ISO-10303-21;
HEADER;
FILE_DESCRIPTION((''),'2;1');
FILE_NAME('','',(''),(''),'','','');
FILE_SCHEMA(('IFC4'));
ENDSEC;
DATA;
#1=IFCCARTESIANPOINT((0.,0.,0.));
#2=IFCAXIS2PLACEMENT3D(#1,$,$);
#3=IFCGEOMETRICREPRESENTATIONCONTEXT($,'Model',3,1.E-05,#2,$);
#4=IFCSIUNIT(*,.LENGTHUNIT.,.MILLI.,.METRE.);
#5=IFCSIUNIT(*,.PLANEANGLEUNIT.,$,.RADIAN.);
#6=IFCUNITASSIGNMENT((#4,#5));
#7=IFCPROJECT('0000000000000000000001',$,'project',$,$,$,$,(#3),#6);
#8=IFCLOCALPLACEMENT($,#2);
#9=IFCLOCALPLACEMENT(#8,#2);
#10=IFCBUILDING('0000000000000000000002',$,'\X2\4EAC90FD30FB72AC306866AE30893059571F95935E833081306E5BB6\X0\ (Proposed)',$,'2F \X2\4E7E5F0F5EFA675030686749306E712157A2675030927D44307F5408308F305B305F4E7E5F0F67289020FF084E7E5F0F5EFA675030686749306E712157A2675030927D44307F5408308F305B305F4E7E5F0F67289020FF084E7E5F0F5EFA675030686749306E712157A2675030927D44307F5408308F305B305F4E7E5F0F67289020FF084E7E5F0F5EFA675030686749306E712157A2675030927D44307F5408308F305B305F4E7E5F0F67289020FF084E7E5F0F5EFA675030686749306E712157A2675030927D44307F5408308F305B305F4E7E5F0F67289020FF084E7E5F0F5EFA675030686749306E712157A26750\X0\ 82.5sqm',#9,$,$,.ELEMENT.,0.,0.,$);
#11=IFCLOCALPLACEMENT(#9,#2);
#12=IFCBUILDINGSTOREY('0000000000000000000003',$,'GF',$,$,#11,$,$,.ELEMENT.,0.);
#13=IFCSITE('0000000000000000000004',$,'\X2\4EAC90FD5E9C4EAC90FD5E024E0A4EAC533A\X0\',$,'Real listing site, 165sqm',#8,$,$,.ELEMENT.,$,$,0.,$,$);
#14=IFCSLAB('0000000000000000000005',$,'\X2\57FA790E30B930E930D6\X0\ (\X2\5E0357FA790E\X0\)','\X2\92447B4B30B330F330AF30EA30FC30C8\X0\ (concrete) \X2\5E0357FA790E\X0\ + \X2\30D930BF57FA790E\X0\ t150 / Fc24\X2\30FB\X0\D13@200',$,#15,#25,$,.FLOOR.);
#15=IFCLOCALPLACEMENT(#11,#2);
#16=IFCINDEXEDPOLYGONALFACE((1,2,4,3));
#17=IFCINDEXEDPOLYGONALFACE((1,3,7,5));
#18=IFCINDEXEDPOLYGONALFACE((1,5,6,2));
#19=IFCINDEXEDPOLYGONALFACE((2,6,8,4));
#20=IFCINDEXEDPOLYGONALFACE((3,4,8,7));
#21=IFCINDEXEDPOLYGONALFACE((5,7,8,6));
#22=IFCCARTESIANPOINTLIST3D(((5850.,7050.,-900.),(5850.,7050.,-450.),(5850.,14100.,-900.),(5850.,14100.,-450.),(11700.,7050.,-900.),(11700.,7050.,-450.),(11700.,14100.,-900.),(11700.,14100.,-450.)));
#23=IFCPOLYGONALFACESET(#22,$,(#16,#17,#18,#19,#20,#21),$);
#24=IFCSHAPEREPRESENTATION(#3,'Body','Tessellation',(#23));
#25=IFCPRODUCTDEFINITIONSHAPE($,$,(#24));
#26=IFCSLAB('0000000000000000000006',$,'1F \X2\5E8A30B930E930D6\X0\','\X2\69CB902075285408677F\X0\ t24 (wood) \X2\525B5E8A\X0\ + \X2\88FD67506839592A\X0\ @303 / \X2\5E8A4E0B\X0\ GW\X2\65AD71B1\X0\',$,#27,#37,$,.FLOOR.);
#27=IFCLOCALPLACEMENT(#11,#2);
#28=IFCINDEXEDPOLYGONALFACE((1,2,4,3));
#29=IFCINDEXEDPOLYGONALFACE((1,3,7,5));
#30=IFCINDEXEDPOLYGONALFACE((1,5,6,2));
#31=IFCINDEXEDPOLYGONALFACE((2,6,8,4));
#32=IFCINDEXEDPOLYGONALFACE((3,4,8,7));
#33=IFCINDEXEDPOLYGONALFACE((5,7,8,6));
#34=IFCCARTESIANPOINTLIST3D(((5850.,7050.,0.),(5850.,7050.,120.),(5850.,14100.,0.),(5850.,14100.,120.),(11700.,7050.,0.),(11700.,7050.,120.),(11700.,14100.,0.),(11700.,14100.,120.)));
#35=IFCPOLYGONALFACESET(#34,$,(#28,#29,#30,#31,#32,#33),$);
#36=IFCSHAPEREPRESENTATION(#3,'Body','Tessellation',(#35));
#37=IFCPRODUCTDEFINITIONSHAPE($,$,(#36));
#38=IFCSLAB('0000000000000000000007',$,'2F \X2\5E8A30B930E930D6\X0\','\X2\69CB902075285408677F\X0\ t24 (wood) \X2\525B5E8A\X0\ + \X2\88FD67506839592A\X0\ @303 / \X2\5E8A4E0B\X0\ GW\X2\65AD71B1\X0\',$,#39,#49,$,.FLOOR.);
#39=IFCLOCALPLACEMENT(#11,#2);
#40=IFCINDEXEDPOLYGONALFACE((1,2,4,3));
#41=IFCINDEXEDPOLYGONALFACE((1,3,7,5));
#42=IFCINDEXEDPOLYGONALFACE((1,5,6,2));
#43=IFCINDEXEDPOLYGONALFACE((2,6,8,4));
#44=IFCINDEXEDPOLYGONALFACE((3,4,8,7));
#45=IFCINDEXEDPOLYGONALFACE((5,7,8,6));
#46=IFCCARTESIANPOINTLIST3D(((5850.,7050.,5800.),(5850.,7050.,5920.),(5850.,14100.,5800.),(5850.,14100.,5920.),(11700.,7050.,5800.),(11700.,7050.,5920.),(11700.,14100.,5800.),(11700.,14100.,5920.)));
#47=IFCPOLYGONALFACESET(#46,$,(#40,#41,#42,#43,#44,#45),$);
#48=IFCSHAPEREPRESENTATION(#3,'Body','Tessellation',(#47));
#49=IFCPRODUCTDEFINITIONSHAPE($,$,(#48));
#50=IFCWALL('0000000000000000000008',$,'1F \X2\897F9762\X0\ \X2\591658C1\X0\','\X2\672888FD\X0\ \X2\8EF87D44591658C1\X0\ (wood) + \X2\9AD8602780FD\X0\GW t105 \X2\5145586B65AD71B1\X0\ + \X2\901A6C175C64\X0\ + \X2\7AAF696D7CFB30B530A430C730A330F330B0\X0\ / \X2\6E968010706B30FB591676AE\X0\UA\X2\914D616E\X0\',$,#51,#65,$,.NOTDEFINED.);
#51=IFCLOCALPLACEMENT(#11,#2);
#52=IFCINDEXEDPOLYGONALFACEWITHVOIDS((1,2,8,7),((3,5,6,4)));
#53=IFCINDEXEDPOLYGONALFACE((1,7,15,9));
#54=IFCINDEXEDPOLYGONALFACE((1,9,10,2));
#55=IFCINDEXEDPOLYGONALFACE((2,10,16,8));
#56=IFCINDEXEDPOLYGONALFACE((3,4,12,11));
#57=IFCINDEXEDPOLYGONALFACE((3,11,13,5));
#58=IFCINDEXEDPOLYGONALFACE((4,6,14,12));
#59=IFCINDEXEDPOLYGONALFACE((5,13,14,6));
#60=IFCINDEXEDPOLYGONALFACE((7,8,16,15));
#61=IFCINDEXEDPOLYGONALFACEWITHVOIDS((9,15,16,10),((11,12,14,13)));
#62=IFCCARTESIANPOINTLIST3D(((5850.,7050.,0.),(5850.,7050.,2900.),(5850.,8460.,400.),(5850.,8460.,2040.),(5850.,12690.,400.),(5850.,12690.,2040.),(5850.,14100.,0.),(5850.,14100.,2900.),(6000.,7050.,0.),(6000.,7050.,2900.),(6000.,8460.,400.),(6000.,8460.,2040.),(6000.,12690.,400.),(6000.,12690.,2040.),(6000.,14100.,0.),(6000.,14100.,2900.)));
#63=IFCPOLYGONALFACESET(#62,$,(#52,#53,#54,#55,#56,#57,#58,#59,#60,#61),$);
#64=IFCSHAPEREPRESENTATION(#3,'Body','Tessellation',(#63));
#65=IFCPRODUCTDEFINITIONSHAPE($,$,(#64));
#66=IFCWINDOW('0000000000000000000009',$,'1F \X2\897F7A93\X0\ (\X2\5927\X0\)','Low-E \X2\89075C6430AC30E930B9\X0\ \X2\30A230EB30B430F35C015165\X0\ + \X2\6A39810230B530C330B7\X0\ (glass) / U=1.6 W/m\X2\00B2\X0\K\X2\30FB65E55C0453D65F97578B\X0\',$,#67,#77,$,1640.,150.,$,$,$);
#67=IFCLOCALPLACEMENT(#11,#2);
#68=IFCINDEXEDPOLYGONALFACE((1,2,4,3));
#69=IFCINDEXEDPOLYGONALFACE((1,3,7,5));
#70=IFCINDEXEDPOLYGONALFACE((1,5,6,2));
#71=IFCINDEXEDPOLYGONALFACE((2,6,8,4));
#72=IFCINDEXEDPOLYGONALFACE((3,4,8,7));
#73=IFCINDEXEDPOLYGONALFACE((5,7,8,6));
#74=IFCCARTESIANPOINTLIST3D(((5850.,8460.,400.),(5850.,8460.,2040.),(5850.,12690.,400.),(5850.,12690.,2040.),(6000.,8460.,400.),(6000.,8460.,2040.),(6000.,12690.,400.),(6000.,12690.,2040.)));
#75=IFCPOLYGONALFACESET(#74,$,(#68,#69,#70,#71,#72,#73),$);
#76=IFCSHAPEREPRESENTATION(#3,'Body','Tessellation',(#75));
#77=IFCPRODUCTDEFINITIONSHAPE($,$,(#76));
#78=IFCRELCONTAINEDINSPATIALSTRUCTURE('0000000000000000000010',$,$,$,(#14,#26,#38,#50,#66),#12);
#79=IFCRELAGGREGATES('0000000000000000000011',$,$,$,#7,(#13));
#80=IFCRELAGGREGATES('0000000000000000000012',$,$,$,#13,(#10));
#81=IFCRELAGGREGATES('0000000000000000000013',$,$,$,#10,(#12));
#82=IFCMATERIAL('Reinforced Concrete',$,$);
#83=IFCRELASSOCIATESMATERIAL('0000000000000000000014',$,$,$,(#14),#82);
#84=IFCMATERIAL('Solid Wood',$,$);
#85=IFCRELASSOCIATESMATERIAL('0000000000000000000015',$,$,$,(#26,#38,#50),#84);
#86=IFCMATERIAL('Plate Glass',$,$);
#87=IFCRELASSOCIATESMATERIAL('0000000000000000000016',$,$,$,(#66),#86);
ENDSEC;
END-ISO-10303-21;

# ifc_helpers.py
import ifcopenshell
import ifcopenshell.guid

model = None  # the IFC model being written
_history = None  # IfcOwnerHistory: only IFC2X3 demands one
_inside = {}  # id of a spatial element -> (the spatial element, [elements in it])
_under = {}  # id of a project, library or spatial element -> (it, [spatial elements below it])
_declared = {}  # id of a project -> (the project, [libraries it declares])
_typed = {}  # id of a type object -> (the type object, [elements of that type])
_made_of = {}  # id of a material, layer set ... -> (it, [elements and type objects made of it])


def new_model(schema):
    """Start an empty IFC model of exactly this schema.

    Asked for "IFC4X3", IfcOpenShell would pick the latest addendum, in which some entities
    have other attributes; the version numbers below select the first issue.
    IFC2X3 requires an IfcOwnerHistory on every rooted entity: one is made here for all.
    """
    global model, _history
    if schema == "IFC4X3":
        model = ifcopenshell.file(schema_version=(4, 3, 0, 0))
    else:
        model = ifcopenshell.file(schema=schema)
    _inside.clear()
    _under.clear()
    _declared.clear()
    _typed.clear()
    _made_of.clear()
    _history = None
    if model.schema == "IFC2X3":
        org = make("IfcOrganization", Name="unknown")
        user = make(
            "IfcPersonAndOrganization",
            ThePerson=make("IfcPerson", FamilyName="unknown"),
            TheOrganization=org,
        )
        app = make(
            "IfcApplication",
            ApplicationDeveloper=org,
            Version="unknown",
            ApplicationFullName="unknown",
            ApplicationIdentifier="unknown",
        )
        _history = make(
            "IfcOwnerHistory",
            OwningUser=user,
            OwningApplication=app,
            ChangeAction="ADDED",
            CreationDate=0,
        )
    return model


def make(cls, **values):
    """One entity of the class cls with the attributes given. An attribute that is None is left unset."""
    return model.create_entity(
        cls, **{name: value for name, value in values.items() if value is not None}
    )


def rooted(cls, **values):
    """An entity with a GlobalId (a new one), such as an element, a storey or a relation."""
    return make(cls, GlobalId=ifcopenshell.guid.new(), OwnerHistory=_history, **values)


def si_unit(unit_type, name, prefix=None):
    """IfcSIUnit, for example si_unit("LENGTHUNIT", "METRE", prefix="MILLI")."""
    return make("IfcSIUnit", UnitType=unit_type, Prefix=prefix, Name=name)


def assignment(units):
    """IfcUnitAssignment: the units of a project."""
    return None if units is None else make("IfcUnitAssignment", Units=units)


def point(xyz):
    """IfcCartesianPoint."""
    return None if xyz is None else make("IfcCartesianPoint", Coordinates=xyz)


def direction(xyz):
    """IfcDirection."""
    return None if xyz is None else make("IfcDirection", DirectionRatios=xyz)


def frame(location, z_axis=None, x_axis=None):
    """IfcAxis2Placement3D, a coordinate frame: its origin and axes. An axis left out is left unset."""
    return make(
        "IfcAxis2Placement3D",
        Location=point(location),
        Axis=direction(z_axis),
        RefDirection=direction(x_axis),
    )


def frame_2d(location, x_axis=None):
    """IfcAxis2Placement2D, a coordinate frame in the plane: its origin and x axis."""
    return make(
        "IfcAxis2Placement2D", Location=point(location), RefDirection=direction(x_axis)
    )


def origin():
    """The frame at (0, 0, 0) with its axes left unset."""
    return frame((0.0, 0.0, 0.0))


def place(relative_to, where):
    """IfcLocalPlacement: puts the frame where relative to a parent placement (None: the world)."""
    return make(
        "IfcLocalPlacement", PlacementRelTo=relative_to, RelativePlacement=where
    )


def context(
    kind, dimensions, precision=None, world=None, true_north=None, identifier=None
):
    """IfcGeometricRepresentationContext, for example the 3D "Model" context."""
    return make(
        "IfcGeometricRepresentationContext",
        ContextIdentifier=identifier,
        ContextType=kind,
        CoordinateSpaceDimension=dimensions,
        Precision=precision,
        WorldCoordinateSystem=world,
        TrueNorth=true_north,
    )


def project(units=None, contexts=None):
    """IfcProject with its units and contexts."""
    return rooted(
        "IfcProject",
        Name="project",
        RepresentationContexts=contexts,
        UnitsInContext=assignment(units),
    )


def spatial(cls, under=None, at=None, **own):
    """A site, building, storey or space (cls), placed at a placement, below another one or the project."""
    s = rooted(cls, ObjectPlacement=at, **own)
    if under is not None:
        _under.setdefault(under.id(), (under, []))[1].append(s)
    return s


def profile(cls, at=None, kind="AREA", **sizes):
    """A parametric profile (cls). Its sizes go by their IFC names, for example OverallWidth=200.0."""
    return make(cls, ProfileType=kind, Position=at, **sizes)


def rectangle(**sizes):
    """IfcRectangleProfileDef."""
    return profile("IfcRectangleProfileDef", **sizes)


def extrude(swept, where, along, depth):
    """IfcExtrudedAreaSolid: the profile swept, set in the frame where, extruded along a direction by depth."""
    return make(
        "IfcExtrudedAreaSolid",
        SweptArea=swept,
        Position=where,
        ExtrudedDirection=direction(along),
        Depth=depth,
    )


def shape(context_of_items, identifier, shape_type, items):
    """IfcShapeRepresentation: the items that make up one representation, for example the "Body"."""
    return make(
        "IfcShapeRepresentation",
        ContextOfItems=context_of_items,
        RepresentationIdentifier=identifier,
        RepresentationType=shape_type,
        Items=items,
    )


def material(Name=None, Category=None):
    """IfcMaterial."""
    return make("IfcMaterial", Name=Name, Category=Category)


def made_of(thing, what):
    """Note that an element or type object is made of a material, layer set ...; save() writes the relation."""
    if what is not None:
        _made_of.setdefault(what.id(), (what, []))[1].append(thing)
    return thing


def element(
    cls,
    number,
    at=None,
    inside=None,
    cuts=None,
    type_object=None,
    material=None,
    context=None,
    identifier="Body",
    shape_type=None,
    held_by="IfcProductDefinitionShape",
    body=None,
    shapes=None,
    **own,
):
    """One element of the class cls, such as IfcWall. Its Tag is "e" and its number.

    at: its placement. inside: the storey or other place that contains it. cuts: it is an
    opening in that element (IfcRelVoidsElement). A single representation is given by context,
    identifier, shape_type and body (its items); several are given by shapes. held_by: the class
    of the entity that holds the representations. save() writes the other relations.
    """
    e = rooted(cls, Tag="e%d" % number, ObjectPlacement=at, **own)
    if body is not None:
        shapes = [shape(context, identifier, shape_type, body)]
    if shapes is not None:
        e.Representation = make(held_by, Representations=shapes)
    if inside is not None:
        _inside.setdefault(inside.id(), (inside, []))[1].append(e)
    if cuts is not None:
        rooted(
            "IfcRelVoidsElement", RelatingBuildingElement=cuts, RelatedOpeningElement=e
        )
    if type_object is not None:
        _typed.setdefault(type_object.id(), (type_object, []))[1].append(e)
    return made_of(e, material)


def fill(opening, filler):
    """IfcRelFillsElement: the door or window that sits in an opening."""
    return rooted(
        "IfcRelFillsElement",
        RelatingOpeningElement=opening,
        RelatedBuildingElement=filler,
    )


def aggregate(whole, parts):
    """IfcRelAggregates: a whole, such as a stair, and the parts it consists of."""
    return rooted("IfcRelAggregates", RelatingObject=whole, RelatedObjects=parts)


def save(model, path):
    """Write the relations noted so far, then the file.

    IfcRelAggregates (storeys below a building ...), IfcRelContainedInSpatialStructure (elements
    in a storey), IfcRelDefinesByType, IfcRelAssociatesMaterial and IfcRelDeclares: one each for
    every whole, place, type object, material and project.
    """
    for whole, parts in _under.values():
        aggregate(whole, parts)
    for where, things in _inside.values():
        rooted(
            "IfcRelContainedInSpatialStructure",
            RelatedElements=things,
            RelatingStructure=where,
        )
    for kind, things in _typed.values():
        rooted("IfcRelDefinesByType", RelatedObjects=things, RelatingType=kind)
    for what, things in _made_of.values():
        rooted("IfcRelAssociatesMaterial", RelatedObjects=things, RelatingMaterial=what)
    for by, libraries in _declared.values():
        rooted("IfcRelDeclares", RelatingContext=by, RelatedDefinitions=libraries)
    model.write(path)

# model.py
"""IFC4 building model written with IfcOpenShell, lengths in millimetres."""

from ifc_helpers import new_model, si_unit, frame, frame_2d, origin, place, context, project, spatial, rectangle, extrude, material, element, fill, save


model = new_model("IFC4")

# Units and contexts
model_context = context("Model", 3, precision=1e-05, world=origin())
ifc_project = project(units=[si_unit("LENGTHUNIT", "METRE", prefix="MILLI"), si_unit("PLANEANGLEUNIT", "RADIAN")], contexts=[model_context])

# Site, building, storey
site_placement = place(None, origin())
site = spatial("IfcSite", under=ifc_project, at=site_placement, Name="京都府京都市上京区", ObjectType="Real listing site, 165sqm", CompositionType="ELEMENT", RefElevation=0.0)
building_placement = place(site_placement, origin())
building = spatial("IfcBuilding", under=site, at=building_placement, Name="京都・犬と暮らす土間広めの家 (Proposed)", ObjectType="2F 乾式建材と杉の無垢材を組み合わせた乾式木造（乾式建材と杉の無垢材を組み合わせた乾式木造（乾式建材と杉の無垢材を組み合わせた乾式木造（乾式建材と杉の無垢材を組み合わせた乾式木造（乾式建材と杉の無垢材を組み合わせた乾式木造（乾式建材と杉の無垢材 82.5sqm", CompositionType="ELEMENT", ElevationOfRefHeight=0.0, ElevationOfTerrain=0.0)
storey_placement = place(building_placement, origin())
storey = spatial("IfcBuildingStorey", under=building, at=storey_placement, Name="GF", CompositionType="ELEMENT", Elevation=0.0)

# Shared definitions
ifc_material_1 = material(Name="Solid Wood")

# Slabs
ifc_material_2 = material(Name="Reinforced Concrete")
slab_1_placement = place(storey_placement, frame((2925.0, 3525.0, -450.0)))
element("IfcSlab", 1, at=slab_1_placement, inside=storey, material=ifc_material_2, Name="基礎スラブ (布基礎)", Description="鉄筋コンクリート (concrete) 布基礎 + ベタ基礎 t150 / Fc24・D13@200", PredefinedType="FLOOR", context=model_context, shape_type="SweptSolid", body=[
    extrude(rectangle(XDim=5850.0, YDim=7050.0, at=frame_2d((2925.0, 3525.0))), frame((2925.0, 3525.0, -450.0)), (0.0, 0.0, 1.0), 450.0),
])
slab_2_placement = place(storey_placement, frame((2925.0, 3525.0, 0.0)))
element("IfcSlab", 2, at=slab_2_placement, inside=storey, material=ifc_material_1, Name="1F 床スラブ", Description="構造用合板 t24 (wood) 剛床 + 製材根太 @303 / 床下 GW断熱", PredefinedType="FLOOR", context=model_context, shape_type="SweptSolid", body=[
    extrude(rectangle(XDim=5850.0, YDim=7050.0, at=frame_2d((2925.0, 3525.0))), frame((2925.0, 3525.0, 0.0)), (0.0, 0.0, 1.0), 120.0),
])
slab_3_placement = place(storey_placement, frame((2925.0, 3525.0, 2900.0)))
element("IfcSlab", 3, at=slab_3_placement, inside=storey, material=ifc_material_1, Name="2F 床スラブ", Description="構造用合板 t24 (wood) 剛床 + 製材根太 @303 / 床下 GW断熱", PredefinedType="FLOOR", context=model_context, shape_type="SweptSolid", body=[
    extrude(rectangle(XDim=5850.0, YDim=7050.0, at=frame_2d((2925.0, 3525.0))), frame((2925.0, 3525.0, 2900.0)), (0.0, 0.0, 1.0), 120.0),
])

# Shared definitions
ifc_material_3 = material(Name="Plate Glass")

# Wall, opening, window
wall_1_placement = place(storey_placement, frame((2925.0, 3525.0, 0.0)))
wall_1 = element("IfcWall", 4, at=wall_1_placement, inside=storey, material=ifc_material_1, Name="1F 西面 外壁", Description="木製 軸組外壁 (wood) + 高性能GW t105 充填断熱 + 通気層 + 窯業系サイディング / 準耐火・外皮UA配慮", PredefinedType="NOTDEFINED", context=model_context, shape_type="SweptSolid", body=[
    extrude(rectangle(XDim=150.0, YDim=7050.0, at=frame_2d((75.0, 3525.0))), frame((2925.0, 3525.0, 0.0)), (0.0, 0.0, 1.0), 2900.0),
])
opening_1_placement = place(storey_placement, frame((2925.0, 4230.0, 200.0)))
opening_1 = element("IfcOpeningElement", 5, at=opening_1_placement, cuts=wall_1, PredefinedType="NOTDEFINED", context=model_context, shape_type="SweptSolid", body=[
    extrude(rectangle(XDim=150.0, YDim=4230.0, at=frame_2d((75.0, 2115.0))), frame((2925.0, 4230.0, 200.0)), (0.0, 0.0, 1.0), 1640.0),
])
window_1_placement = place(storey_placement, frame((2925.0, 4230.0, 200.0)))
window_1 = element("IfcWindow", 6, at=window_1_placement, inside=storey, material=ifc_material_3, Name="1F 西窓 (大)", Description="Low-E 複層ガラス アルゴン封入 + 樹脂サッシ (glass) / U=1.6 W/m²K・日射取得型", OverallHeight=1640.0, OverallWidth=150.0, context=model_context, shape_type="SweptSolid", body=[
    extrude(rectangle(XDim=150.0, YDim=4230.0, at=frame_2d((75.0, 2115.0))), frame((2925.0, 4230.0, 200.0)), (0.0, 0.0, 1.0), 1640.0),
])
fill(opening_1, window_1)

save(model, "model.ifc")
